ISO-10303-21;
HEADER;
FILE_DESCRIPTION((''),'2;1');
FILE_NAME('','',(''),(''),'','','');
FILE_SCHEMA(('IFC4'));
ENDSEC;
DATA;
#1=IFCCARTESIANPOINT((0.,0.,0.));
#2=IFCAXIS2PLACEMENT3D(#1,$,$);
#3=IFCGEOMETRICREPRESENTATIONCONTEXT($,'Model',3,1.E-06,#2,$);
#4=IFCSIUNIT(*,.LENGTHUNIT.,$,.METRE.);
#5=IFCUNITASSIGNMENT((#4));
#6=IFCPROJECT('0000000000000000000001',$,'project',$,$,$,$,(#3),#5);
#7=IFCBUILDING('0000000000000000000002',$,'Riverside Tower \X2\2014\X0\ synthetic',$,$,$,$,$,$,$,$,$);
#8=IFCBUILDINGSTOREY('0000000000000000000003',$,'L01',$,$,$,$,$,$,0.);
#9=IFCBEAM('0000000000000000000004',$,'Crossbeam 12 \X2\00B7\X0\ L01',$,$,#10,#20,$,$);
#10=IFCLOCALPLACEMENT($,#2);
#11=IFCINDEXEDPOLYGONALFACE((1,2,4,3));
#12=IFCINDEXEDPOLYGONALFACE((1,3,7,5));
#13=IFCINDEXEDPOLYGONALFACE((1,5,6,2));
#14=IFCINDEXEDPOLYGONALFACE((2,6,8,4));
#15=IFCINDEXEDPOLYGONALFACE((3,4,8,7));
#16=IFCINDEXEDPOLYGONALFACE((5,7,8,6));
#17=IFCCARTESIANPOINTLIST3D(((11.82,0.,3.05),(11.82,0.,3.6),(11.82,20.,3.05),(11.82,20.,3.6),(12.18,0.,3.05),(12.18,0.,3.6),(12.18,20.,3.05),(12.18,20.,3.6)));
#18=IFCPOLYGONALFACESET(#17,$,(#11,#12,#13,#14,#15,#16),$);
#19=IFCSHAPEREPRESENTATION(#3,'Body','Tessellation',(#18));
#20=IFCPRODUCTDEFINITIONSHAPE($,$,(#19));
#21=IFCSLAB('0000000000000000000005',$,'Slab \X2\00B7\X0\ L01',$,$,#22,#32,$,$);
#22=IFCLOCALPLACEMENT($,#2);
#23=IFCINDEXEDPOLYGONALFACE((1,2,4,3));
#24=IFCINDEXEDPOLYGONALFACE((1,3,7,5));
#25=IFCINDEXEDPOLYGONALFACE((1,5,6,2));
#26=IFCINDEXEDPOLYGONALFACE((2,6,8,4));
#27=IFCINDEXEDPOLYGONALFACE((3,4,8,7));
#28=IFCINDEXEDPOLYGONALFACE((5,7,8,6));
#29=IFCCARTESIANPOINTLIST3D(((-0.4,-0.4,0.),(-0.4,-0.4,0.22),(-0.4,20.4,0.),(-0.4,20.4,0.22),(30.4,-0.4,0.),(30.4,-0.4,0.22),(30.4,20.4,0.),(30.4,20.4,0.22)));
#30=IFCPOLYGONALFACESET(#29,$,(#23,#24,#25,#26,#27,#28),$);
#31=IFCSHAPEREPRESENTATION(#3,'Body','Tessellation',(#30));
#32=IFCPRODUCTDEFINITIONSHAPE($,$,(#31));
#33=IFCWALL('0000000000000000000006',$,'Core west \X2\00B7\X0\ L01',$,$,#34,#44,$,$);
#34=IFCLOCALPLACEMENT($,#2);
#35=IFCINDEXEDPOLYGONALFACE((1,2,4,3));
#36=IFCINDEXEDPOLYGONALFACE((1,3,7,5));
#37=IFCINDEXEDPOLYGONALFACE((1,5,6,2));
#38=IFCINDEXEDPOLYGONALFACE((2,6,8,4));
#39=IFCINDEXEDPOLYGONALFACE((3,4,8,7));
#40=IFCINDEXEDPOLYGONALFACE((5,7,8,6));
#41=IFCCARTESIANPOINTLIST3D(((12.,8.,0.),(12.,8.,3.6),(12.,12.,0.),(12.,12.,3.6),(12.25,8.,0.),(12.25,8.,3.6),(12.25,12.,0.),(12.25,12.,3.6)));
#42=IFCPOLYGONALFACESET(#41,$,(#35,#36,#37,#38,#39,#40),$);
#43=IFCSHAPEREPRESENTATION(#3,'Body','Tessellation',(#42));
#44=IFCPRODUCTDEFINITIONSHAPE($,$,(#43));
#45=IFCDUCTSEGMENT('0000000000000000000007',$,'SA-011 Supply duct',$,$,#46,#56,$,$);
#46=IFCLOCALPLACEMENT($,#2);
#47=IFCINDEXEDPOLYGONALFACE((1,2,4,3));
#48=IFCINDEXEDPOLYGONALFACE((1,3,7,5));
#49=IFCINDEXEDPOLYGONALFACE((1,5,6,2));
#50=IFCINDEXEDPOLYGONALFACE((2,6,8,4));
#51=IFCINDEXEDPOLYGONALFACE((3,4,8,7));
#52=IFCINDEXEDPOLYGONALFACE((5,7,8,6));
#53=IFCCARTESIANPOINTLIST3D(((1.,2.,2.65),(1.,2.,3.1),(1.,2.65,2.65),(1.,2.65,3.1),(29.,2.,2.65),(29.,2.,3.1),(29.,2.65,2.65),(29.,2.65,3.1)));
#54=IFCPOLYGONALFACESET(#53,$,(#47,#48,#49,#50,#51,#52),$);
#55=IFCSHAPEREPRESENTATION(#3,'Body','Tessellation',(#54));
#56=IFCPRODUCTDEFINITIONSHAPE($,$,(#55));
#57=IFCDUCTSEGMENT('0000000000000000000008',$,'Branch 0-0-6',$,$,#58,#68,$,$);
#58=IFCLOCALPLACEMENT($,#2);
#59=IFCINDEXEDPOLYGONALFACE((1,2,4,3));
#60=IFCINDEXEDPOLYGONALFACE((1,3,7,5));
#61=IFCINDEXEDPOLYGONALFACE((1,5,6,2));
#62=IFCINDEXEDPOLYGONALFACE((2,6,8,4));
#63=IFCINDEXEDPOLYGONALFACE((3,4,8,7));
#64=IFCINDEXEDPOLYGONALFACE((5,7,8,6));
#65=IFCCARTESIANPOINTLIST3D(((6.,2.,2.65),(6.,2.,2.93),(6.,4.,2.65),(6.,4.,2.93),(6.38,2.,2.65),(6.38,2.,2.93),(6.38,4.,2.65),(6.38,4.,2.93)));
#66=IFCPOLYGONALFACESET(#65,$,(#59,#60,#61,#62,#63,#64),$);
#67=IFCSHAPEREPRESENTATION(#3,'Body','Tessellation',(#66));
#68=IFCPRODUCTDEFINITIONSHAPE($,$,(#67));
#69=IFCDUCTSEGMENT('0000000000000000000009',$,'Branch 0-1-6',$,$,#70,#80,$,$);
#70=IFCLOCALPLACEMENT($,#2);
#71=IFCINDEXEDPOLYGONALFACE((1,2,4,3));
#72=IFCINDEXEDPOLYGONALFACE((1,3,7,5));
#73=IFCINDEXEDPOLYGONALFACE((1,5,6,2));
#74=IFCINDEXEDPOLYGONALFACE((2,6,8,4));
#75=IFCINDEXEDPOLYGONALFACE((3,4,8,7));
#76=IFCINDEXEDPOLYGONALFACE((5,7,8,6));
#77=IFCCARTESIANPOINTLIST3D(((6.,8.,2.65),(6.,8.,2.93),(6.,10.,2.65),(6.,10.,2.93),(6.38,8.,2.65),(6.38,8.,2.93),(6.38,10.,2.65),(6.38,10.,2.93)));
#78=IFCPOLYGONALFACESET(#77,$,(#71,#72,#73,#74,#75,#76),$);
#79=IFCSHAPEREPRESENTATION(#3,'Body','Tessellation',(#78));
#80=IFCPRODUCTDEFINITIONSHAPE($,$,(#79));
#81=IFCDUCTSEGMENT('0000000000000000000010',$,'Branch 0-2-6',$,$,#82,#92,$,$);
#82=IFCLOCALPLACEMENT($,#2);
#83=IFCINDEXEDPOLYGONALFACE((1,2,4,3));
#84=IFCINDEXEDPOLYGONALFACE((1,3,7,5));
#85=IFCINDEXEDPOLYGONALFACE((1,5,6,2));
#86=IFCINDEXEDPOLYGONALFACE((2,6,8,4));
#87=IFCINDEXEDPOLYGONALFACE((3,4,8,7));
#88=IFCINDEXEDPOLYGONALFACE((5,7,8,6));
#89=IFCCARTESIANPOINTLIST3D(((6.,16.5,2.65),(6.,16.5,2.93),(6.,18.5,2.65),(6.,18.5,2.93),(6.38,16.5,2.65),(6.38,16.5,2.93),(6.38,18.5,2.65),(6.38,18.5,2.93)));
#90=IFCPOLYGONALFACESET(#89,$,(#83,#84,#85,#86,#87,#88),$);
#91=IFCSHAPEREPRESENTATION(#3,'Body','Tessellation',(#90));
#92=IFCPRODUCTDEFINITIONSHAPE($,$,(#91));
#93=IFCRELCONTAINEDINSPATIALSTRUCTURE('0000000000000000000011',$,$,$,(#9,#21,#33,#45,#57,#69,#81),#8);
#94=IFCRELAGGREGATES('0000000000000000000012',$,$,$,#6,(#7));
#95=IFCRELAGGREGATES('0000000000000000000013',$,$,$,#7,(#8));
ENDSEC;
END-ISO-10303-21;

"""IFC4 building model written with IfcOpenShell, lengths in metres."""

from ifc_helpers import new_model, si_unit, frame, origin, place, context, project, spatial, rectangle, extrude, element, save


model = new_model("IFC4")

# Units and contexts
model_context = context("Model", 3, precision=1e-06, world=origin())
ifc_project = project(units=[si_unit("LENGTHUNIT", "METRE")], contexts=[model_context])

# Building, storey
building = spatial("IfcBuilding", under=ifc_project, Name="Riverside Tower — synthetic")
storey = spatial("IfcBuildingStorey", under=building, Name="L01", Elevation=0.0)

# Beam
for number, where, name in (
    (1, (12.0, 10.0, 3.05), "Crossbeam 12 · L01"),
):
    element("IfcBeam", number, at=place(None, frame(where)), inside=storey, Name=name, context=model_context, shape_type="SweptSolid", body=[
        extrude(rectangle(XDim=0.36, YDim=20.0), origin(), (0.0, 0.0, 1.0), 0.55),
    ])

# Slab
slab_placement = place(None, frame((15.0, 10.0, 0.0)))
element("IfcSlab", 2, at=slab_placement, inside=storey, Name="Slab · L01", context=model_context, shape_type="SweptSolid", body=[
    extrude(rectangle(XDim=30.8, YDim=20.8), origin(), (0.0, 0.0, 1.0), 0.22),
])

# Wall
wall_placement = place(None, frame((12.125, 10.0, 0.0)))
element("IfcWall", 3, at=wall_placement, inside=storey, Name="Core west · L01", context=model_context, shape_type="SweptSolid", body=[
    extrude(rectangle(XDim=0.25, YDim=4.0), origin(), (0.0, 0.0, 1.0), 3.6),
])

# Duct segments
duct_segment_placement = place(None, frame((15.0, 2.325, 2.65)))
element("IfcDuctSegment", 4, at=duct_segment_placement, inside=storey, Name="SA-011 Supply duct", context=model_context, shape_type="SweptSolid", body=[
    extrude(rectangle(XDim=28.0, YDim=0.65), origin(), (0.0, 0.0, 1.0), 0.45),
])
for number, where, name in (
    (5, (6.19, 3.0, 2.65), "Branch 0-0-6"),
    (6, (6.19, 9.0, 2.65), "Branch 0-1-6"),
    (7, (6.19, 17.5, 2.65), "Branch 0-2-6"),
):
    element("IfcDuctSegment", number, at=place(None, frame(where)), inside=storey, Name=name, context=model_context, shape_type="SweptSolid", body=[
        extrude(rectangle(XDim=0.38, YDim=2.0), origin(), (0.0, 0.0, 1.0), 0.28),
    ])

save(model, "model.ifc")
